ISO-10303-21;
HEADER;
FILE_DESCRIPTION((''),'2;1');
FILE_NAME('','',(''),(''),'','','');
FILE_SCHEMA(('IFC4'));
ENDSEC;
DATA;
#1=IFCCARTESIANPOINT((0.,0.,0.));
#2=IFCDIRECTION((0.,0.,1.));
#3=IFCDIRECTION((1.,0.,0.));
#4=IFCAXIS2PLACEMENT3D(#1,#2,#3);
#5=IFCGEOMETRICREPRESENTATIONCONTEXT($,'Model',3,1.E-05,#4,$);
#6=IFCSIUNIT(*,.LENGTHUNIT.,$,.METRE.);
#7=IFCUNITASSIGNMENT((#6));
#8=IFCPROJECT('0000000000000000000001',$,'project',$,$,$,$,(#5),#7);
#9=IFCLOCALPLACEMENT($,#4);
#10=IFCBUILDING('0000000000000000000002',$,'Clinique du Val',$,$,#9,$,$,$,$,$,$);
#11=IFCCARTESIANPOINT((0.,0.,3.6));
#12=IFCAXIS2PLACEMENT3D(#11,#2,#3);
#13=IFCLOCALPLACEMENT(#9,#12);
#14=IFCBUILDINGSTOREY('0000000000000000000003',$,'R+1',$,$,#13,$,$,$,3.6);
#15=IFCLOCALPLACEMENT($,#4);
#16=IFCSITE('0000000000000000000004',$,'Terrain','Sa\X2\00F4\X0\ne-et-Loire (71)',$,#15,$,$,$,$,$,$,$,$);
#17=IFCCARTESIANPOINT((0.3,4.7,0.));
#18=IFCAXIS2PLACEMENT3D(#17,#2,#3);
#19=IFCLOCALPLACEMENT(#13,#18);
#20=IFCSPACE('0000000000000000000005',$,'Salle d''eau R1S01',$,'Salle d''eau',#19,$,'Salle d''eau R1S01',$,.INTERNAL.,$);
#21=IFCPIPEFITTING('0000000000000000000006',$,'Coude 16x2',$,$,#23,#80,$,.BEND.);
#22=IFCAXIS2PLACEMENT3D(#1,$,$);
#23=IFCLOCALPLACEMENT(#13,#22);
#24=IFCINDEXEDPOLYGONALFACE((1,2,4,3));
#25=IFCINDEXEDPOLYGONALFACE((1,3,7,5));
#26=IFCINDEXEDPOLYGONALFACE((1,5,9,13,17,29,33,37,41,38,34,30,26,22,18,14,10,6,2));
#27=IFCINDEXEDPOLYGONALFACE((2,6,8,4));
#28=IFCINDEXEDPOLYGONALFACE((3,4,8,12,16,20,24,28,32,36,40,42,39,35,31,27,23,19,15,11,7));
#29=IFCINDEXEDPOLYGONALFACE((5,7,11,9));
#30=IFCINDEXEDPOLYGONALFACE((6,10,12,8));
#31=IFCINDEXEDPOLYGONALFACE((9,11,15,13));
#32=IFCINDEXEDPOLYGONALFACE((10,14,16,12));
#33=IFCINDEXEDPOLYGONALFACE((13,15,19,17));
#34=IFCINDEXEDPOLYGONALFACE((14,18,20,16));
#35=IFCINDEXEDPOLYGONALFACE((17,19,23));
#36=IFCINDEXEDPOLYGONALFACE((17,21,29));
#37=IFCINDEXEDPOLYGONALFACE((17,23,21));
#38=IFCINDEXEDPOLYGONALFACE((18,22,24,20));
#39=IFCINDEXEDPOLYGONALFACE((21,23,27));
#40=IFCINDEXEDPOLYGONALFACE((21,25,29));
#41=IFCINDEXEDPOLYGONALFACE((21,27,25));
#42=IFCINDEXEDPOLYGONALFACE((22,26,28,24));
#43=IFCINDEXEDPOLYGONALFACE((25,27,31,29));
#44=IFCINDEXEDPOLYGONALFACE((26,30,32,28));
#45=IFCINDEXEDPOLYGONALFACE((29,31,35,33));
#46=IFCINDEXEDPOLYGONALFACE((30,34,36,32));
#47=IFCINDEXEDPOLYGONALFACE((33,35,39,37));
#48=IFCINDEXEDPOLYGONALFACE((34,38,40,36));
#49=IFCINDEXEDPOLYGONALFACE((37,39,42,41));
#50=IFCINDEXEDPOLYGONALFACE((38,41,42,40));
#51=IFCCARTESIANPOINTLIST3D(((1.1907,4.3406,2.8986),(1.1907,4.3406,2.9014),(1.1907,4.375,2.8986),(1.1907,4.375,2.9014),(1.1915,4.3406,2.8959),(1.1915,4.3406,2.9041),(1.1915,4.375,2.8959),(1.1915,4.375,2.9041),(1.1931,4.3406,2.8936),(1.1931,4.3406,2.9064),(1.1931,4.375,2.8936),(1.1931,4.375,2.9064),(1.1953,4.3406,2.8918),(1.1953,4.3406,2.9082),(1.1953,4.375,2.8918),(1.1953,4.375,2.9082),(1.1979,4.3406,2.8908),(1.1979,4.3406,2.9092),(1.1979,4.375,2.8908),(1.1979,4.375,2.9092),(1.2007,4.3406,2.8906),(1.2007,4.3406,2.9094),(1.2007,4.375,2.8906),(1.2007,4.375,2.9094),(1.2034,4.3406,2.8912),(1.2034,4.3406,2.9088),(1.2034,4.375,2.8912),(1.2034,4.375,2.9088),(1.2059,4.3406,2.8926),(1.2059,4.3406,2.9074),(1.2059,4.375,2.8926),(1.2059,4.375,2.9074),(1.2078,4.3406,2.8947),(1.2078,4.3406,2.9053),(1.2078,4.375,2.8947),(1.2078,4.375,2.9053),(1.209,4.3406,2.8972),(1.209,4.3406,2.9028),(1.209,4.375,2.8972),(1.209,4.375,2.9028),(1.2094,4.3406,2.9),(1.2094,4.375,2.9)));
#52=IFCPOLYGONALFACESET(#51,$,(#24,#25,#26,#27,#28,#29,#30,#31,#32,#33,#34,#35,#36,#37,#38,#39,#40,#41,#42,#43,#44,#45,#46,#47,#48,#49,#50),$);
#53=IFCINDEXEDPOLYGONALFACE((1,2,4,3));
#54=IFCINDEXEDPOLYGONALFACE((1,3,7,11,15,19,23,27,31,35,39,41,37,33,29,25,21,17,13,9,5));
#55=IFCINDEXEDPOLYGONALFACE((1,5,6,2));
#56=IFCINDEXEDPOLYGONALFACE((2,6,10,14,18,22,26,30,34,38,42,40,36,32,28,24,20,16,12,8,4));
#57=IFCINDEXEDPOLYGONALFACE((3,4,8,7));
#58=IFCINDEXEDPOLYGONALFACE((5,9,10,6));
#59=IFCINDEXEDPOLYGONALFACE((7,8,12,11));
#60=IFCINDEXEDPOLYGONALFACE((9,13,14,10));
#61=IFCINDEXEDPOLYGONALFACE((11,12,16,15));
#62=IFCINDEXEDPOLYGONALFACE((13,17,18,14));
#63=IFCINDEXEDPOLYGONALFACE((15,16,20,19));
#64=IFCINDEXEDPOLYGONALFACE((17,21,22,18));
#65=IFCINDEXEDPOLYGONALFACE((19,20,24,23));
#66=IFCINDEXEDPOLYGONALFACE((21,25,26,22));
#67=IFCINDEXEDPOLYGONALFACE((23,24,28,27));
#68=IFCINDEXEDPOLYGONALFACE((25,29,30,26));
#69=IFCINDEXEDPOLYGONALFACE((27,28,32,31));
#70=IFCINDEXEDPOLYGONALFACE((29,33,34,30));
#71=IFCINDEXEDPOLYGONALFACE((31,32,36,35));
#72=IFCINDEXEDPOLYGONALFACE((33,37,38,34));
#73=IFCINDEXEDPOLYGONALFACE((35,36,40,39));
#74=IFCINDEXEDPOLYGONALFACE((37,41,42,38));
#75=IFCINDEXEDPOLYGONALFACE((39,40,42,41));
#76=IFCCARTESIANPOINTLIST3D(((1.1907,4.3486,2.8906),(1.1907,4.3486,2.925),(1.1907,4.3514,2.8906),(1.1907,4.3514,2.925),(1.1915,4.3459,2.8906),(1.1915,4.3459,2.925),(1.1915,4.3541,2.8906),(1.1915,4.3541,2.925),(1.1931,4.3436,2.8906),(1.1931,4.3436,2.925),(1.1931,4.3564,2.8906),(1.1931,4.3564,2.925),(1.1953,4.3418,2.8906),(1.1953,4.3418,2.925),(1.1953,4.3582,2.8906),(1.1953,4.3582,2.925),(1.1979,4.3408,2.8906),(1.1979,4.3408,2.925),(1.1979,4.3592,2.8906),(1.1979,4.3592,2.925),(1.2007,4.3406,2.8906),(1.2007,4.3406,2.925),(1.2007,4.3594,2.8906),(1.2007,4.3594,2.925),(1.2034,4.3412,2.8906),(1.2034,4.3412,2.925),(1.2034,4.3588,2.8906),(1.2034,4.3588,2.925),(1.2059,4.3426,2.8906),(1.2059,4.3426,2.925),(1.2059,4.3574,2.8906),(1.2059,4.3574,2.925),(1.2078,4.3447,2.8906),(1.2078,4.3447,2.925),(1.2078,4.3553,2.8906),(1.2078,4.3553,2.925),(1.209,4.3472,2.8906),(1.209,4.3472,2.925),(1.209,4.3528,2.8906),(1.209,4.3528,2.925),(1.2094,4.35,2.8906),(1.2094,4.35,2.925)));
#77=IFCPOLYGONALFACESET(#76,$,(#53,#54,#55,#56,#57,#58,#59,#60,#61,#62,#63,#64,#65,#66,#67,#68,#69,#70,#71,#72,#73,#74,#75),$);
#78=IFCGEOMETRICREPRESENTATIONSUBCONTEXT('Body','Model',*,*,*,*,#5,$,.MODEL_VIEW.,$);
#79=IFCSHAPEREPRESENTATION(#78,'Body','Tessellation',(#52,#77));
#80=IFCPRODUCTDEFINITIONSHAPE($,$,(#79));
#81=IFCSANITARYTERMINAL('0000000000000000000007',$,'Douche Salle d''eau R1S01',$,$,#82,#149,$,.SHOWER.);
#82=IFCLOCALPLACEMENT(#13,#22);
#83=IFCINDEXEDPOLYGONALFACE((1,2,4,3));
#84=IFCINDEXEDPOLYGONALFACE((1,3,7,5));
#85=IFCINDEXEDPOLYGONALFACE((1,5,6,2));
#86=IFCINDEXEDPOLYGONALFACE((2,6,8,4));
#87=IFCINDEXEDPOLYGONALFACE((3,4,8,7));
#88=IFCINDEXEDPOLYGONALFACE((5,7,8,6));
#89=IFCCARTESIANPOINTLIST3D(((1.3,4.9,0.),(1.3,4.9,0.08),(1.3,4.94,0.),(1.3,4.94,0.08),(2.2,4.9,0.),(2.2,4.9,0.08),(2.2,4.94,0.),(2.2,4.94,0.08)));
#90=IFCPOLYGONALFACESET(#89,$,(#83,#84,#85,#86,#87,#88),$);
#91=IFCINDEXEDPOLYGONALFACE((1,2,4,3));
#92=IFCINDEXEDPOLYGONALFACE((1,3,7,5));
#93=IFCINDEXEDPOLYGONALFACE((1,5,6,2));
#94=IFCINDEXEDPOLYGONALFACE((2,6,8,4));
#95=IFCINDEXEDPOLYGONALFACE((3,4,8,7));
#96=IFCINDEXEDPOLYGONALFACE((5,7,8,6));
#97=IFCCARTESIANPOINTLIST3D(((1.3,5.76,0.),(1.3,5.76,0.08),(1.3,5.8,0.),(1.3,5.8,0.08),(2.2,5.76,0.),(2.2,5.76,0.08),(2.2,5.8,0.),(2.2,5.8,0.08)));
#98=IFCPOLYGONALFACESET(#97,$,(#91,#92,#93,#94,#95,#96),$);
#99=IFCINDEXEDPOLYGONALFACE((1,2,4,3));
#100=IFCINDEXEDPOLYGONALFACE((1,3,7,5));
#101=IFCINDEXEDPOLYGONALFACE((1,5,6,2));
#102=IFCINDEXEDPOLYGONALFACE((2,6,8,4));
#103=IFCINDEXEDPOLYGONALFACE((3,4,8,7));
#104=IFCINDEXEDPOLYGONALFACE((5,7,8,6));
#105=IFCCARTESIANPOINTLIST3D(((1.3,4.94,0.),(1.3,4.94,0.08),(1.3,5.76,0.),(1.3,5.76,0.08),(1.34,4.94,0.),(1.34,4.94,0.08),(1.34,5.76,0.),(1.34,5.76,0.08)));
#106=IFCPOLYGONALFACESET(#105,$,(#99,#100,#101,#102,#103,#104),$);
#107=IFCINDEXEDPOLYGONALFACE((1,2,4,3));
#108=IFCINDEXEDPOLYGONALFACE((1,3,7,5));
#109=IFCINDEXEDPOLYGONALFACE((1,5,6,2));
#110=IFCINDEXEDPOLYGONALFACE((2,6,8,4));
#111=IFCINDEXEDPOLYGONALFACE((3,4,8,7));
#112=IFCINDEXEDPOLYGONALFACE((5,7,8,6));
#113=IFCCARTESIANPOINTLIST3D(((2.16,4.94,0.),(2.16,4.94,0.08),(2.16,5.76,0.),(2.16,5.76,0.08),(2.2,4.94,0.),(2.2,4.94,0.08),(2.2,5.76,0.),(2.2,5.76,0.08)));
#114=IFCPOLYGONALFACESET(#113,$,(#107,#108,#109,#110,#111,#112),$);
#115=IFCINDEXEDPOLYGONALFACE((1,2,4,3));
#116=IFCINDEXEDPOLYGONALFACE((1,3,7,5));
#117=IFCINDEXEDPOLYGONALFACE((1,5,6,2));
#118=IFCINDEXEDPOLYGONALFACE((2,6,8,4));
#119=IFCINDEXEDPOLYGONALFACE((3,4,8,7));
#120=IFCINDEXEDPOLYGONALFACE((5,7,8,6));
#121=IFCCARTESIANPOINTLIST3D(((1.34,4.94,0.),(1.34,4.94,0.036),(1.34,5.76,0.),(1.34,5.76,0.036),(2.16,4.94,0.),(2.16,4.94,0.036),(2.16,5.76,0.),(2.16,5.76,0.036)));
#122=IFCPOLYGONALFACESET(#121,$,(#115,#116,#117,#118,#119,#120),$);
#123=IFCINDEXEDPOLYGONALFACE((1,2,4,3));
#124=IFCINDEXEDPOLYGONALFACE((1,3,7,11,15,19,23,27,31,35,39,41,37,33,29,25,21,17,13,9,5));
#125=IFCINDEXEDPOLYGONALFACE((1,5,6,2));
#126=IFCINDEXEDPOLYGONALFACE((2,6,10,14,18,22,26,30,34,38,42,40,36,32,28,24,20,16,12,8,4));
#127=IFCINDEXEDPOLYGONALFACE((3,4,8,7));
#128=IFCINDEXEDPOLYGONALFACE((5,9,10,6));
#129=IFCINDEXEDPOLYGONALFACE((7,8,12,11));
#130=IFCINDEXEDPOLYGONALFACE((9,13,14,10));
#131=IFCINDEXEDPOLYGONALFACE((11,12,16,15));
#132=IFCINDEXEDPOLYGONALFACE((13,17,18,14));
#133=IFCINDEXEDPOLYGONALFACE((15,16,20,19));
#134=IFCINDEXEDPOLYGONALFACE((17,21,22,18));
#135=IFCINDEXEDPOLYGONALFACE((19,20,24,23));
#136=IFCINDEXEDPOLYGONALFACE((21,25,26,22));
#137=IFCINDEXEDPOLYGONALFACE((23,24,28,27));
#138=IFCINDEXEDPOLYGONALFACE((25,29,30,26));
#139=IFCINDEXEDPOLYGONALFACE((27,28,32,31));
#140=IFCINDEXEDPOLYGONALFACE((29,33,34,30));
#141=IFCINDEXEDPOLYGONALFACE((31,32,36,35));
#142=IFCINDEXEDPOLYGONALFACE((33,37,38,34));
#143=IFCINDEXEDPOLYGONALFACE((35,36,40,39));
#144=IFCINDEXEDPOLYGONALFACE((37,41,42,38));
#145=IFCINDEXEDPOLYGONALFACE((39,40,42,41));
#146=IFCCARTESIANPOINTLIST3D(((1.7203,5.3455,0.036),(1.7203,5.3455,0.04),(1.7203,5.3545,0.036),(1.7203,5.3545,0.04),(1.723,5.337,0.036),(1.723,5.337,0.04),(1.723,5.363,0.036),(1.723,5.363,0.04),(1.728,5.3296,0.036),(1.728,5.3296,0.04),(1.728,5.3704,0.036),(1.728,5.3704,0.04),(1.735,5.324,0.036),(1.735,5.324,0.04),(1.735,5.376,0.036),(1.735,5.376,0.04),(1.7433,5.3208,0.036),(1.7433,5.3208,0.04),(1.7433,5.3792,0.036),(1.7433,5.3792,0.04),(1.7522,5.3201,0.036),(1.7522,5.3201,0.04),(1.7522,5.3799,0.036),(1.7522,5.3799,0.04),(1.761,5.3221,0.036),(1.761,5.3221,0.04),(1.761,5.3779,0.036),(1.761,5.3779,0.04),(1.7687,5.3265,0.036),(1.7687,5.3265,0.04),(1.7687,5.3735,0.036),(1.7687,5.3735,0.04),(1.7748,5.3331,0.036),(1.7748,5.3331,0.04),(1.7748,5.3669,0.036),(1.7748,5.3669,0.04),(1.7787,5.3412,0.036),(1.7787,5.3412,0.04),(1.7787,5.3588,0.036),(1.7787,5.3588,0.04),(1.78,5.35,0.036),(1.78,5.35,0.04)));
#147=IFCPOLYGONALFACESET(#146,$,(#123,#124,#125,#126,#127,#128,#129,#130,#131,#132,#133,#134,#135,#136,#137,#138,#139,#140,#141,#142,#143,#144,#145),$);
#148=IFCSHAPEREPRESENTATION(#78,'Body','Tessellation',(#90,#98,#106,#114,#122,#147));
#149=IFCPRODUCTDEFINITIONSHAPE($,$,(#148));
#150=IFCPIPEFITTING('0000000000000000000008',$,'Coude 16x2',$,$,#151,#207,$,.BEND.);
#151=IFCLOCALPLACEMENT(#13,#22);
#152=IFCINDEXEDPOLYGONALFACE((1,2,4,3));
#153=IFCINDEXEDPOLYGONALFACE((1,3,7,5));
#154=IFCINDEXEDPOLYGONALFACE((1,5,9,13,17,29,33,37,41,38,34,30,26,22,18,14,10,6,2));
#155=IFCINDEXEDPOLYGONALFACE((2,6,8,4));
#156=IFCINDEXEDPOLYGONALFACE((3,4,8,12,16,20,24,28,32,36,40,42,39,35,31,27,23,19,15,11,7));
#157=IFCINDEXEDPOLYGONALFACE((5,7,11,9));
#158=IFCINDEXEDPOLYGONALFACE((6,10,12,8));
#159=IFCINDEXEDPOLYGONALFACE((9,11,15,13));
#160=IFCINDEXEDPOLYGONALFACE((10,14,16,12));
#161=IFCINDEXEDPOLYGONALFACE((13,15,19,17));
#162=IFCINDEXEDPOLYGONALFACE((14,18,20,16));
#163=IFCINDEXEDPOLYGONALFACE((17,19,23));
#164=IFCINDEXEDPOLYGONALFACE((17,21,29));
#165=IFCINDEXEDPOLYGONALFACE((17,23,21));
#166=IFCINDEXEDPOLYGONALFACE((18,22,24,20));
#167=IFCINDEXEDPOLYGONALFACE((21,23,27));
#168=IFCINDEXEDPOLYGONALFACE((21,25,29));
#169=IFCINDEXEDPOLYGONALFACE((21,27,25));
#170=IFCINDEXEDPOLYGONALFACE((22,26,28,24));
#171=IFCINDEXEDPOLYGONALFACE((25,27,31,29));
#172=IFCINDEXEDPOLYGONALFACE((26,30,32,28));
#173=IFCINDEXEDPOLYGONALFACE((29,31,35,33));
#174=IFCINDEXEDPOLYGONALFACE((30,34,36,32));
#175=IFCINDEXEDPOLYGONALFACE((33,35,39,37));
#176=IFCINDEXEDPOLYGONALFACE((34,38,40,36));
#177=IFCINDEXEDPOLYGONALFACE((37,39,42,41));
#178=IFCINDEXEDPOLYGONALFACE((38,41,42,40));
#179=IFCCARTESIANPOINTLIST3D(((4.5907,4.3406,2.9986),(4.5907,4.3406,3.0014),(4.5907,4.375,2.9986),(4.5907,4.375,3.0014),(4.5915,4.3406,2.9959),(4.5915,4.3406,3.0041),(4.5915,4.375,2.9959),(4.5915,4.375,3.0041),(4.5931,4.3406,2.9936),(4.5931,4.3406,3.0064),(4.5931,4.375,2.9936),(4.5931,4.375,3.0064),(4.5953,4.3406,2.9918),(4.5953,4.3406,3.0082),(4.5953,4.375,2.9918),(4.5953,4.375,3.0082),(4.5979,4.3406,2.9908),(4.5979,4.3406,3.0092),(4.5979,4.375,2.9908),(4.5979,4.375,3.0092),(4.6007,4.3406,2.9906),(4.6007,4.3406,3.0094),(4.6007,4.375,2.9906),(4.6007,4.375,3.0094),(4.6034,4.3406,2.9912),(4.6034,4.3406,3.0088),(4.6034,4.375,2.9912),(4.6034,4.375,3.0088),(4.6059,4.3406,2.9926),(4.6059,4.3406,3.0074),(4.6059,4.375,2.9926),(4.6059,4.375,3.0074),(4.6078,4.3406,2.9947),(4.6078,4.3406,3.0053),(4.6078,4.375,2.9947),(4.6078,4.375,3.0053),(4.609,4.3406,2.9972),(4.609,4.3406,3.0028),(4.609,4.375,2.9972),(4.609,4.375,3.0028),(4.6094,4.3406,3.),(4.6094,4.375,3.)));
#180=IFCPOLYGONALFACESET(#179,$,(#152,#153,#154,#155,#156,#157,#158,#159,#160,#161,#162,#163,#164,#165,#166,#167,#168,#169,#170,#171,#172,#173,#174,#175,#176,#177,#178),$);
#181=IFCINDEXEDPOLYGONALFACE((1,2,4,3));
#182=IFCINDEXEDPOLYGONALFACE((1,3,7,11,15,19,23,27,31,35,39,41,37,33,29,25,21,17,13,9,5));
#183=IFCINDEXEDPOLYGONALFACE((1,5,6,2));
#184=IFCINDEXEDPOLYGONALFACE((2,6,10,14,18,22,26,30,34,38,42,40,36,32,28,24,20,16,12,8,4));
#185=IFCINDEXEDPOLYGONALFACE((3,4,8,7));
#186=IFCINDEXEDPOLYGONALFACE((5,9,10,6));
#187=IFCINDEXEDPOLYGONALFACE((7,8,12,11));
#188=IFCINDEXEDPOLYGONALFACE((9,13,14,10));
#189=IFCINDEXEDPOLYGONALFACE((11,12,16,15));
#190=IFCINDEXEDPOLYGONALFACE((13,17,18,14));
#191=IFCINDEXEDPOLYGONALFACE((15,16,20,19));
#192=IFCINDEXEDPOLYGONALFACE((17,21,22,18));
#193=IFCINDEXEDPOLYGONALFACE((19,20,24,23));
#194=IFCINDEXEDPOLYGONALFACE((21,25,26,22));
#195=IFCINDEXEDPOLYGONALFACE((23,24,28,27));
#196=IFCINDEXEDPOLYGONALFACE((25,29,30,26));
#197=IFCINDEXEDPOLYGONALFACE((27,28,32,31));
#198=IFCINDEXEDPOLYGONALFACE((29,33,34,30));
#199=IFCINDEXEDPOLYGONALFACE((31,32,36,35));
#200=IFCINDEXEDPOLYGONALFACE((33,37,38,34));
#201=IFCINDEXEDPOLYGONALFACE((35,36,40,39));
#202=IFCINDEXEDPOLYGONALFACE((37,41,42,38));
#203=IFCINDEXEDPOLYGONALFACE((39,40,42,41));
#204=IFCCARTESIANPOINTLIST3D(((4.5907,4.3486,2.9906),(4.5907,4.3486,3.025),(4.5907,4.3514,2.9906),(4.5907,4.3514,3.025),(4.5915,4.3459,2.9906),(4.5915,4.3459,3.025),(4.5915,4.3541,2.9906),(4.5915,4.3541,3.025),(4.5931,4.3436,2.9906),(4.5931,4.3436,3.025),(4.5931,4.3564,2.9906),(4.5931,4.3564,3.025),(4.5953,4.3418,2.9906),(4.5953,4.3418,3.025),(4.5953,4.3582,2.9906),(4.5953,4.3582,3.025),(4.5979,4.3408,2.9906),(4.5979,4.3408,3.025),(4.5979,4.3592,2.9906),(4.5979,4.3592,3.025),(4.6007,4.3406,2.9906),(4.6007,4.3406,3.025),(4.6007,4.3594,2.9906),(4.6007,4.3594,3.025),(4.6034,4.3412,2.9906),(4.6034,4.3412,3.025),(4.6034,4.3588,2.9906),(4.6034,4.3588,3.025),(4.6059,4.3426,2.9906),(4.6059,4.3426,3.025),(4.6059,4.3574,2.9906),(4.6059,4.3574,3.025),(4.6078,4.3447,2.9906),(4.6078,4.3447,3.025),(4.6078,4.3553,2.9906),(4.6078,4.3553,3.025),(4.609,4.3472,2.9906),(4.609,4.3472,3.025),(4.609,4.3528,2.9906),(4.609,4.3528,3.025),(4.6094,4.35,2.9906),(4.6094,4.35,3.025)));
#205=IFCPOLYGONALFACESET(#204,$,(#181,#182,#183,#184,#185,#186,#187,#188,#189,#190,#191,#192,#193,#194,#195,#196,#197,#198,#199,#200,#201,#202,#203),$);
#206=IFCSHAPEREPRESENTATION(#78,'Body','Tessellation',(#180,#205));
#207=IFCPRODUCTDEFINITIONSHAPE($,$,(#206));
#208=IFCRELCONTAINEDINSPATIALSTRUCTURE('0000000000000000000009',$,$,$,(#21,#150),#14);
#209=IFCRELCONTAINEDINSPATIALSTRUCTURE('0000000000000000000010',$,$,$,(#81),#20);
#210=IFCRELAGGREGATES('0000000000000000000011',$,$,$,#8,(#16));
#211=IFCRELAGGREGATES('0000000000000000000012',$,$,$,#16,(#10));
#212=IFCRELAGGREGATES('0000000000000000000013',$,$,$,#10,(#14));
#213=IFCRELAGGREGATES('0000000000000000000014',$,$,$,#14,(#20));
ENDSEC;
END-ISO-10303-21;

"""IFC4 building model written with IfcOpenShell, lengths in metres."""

from ifc_helpers import new_model, si_unit, frame, frame_2d, origin_with_axes, place, context, subcontext, project, spatial, rectangle, circle, extrude, element, save


model = new_model("IFC4")

# Units and contexts
model_context = context("Model", 3, precision=1e-05, world=origin_with_axes())
body_context = subcontext(model_context, "Body", "Model", "MODEL_VIEW")
ifc_project = project(units=[si_unit("LENGTHUNIT", "METRE")], contexts=[model_context])

# Site, building, storey
site_placement = place(None, origin_with_axes())
site = spatial("IfcSite", under=ifc_project, at=site_placement, Name="Terrain", Description="Saône-et-Loire (71)")
building_placement = place(None, origin_with_axes())
building = spatial("IfcBuilding", under=site, at=building_placement, Name="Clinique du Val")
storey_placement = place(building_placement, frame((0.0, 0.0, 3.6), z_axis=(0.0, 0.0, 1.0), x_axis=(1.0, 0.0, 0.0)))
storey = spatial("IfcBuildingStorey", under=building, at=storey_placement, Name="R+1", Elevation=3.6)

# Pipe fitting
for number, where, z_axis, x_axis, name in (
    (1, (1.2, 4.35, 2.9), (0.0, 0.0, 1.0), (1.0, 0.0, 0.0), "Coude 16x2"),
):
    element("IfcPipeFitting", number, at=place(storey_placement, frame(where, z_axis=z_axis, x_axis=x_axis)), inside=storey, Name=name, PredefinedType="BEND", context=body_context, shape_type="SweptSolid", body=[
        extrude(circle(Radius=0.0094), frame((0.0, -0.0094, 0.0), z_axis=(0.0, 1.0, 0.0), x_axis=(1.0, 0.0, 0.0)), (0.0, 0.0, 1.0), 0.0344),
        extrude(circle(Radius=0.0094), frame((0.0, 0.0, -0.0094), z_axis=(0.0, 0.0, 1.0), x_axis=(1.0, 0.0, 0.0)), (0.0, 0.0, 1.0), 0.0344),
    ])

# Shared definitions
space_1_placement = place(storey_placement, frame((0.3, 4.7, 0.0), z_axis=(0.0, 0.0, 1.0), x_axis=(1.0, 0.0, 0.0)))
space_1 = spatial("IfcSpace", under=storey, at=space_1_placement, Name="Salle d'eau R1S01", ObjectType="Salle d'eau", LongName="Salle d'eau R1S01", PredefinedType="INTERNAL")

# Sanitary terminal
sanitary_terminal_placement = place(space_1_placement, frame((1.0, 0.2, 0.0), z_axis=(0.0, 0.0, 1.0), x_axis=(1.0, 0.0, 0.0)))
element("IfcSanitaryTerminal", 2, at=sanitary_terminal_placement, inside=space_1, Name="Douche Salle d'eau R1S01", PredefinedType="SHOWER", context=body_context, shape_type="SweptSolid", body=[
    extrude(rectangle(XDim=0.9, YDim=0.04, at=frame_2d((0.45, 0.02))), origin_with_axes(), (0.0, 0.0, 1.0), 0.08),
    extrude(rectangle(XDim=0.9, YDim=0.04, at=frame_2d((0.45, 0.02))), frame((0.0, 0.86, 0.0), z_axis=(0.0, 0.0, 1.0), x_axis=(1.0, 0.0, 0.0)), (0.0, 0.0, 1.0), 0.08),
    extrude(rectangle(XDim=0.04, YDim=0.82, at=frame_2d((0.02, 0.41))), frame((0.0, 0.04, 0.0), z_axis=(0.0, 0.0, 1.0), x_axis=(1.0, 0.0, 0.0)), (0.0, 0.0, 1.0), 0.08),
    extrude(rectangle(XDim=0.04, YDim=0.82, at=frame_2d((0.02, 0.41))), frame((0.86, 0.04, 0.0), z_axis=(0.0, 0.0, 1.0), x_axis=(1.0, 0.0, 0.0)), (0.0, 0.0, 1.0), 0.08),
    extrude(rectangle(XDim=0.82, YDim=0.82, at=frame_2d((0.41, 0.41))), frame((0.04, 0.04, 0.0), z_axis=(0.0, 0.0, 1.0), x_axis=(1.0, 0.0, 0.0)), (0.0, 0.0, 1.0), 0.036),
    extrude(circle(Radius=0.03), frame((0.45, 0.45, 0.036), z_axis=(0.0, 0.0, 1.0), x_axis=(1.0, 0.0, 0.0)), (0.0, 0.0, 1.0), 0.004),
])

# Pipe fitting
for number, where, z_axis, x_axis, name in (
    (3, (4.6, 4.35, 3.0), (0.0, 0.0, 1.0), (1.0, 0.0, 0.0), "Coude 16x2"),
):
    element("IfcPipeFitting", number, at=place(storey_placement, frame(where, z_axis=z_axis, x_axis=x_axis)), inside=storey, Name=name, PredefinedType="BEND", context=body_context, shape_type="SweptSolid", body=[
        extrude(circle(Radius=0.0094), frame((0.0, -0.0094, 0.0), z_axis=(0.0, 1.0, 0.0), x_axis=(1.0, 0.0, 0.0)), (0.0, 0.0, 1.0), 0.0344),
        extrude(circle(Radius=0.0094), frame((0.0, 0.0, -0.0094), z_axis=(0.0, 0.0, 1.0), x_axis=(1.0, 0.0, 0.0)), (0.0, 0.0, 1.0), 0.0344),
    ])

save(model, "model.ifc")
